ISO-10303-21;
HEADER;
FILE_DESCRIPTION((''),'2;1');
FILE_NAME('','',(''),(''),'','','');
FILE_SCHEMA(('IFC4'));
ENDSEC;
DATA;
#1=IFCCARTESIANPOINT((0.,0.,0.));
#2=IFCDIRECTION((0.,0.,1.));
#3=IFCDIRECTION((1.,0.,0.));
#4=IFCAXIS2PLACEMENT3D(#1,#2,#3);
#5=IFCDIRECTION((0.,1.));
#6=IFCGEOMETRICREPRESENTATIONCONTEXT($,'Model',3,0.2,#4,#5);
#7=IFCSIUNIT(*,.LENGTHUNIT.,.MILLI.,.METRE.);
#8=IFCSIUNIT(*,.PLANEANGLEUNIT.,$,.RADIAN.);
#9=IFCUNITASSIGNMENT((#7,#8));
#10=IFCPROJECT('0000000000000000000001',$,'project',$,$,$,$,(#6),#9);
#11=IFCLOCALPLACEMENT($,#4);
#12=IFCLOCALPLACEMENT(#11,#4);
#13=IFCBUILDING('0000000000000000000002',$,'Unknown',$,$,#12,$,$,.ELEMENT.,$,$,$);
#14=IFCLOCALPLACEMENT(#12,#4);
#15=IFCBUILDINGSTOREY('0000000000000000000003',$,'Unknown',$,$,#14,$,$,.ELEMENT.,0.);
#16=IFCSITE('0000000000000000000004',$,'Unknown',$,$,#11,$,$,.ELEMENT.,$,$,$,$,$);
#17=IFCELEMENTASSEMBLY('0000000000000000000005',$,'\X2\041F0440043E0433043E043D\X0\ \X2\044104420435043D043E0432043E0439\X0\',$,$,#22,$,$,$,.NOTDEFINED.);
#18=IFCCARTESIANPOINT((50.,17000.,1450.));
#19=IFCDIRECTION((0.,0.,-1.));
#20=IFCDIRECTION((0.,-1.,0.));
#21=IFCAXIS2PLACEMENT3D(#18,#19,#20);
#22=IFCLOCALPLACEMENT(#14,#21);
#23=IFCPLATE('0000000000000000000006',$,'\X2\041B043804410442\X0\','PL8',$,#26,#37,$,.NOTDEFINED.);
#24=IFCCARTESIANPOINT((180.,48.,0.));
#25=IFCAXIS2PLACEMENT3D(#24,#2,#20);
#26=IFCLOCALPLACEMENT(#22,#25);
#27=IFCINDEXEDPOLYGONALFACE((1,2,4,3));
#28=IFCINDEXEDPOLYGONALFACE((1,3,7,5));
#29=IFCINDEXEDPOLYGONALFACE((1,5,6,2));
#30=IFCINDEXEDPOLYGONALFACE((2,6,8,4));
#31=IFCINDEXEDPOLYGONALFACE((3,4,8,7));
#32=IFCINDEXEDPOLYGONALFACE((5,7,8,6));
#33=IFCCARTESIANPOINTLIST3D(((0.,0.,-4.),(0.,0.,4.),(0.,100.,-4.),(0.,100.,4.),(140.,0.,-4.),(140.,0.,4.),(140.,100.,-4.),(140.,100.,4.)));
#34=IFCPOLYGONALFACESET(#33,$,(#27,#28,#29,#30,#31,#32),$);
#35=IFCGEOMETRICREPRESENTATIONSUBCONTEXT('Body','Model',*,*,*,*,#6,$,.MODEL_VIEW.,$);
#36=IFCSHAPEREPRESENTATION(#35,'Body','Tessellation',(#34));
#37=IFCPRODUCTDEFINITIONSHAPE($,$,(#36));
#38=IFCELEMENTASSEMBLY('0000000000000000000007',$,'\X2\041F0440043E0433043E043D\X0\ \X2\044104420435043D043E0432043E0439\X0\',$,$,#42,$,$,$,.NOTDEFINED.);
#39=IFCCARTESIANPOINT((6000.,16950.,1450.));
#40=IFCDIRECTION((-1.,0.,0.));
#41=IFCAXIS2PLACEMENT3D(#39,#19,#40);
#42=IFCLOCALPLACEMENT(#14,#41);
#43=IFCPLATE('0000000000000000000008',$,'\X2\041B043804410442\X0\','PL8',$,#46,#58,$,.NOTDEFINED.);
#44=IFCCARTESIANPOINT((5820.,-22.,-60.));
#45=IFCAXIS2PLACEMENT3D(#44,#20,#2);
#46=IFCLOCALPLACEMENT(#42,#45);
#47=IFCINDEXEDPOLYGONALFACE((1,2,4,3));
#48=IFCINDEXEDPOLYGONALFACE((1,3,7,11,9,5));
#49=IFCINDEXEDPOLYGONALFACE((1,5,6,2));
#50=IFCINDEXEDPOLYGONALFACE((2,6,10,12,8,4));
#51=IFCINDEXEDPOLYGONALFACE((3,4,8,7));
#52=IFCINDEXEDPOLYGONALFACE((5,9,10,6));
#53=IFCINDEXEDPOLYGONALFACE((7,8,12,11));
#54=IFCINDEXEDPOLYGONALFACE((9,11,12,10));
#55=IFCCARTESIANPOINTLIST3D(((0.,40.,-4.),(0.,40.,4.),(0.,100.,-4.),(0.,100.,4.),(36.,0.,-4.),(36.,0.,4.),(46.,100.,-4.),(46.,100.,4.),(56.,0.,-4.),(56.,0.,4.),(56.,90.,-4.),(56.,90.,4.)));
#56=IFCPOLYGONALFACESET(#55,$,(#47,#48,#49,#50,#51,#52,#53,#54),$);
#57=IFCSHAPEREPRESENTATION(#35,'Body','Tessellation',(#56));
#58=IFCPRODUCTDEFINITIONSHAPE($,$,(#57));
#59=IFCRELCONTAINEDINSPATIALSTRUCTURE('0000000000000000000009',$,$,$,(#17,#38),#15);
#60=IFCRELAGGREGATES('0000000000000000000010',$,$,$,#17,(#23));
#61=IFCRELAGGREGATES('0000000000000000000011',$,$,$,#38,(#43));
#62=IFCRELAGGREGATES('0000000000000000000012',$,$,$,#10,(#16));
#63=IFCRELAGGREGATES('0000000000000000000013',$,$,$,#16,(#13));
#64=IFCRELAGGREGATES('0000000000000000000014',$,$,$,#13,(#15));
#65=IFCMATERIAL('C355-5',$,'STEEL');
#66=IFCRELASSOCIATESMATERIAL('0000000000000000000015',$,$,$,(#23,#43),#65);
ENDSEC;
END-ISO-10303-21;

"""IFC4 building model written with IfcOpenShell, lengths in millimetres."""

from ifc_helpers import new_model, si_unit, direction, frame, origin_with_axes, place, context, subcontext, project, spatial, line, indexed_curve, outline, extrude, material, element, aggregate, save


model = new_model("IFC4")

# Units and contexts
model_context = context("Model", 3, precision=0.2, world=origin_with_axes(), true_north=direction((0.0, 1.0)))
body_context = subcontext(model_context, "Body", "Model", "MODEL_VIEW")
ifc_project = project(units=[si_unit("LENGTHUNIT", "METRE", prefix="MILLI"), si_unit("PLANEANGLEUNIT", "RADIAN")], contexts=[model_context])

# Site, building, storey
site_placement = place(None, origin_with_axes())
site = spatial("IfcSite", under=ifc_project, at=site_placement, Name="Unknown", CompositionType="ELEMENT")
building_placement = place(site_placement, origin_with_axes())
building = spatial("IfcBuilding", under=site, at=building_placement, Name="Unknown", CompositionType="ELEMENT")
storey_placement = place(building_placement, origin_with_axes())
storey = spatial("IfcBuildingStorey", under=building, at=storey_placement, Name="Unknown", CompositionType="ELEMENT", Elevation=0.0)

# Element assemblies, plates
ifc_material_1 = material(Name="C355-5", Category="STEEL")
assembly_1_placement = place(storey_placement, frame((50.0, 17000.0, 1450.0), z_axis=(0.0, 0.0, -1.0), x_axis=(0.0, -1.0, 0.0)))
assembly_1 = element("IfcElementAssembly", 1, at=assembly_1_placement, inside=storey, Name="Прогон стеновой", PredefinedType="NOTDEFINED")
plate_1_placement = place(assembly_1_placement, frame((180.0, 48.0, 0.0), z_axis=(0.0, 0.0, 1.0), x_axis=(0.0, -1.0, 0.0)))
plate_1 = element("IfcPlate", 2, at=plate_1_placement, material=ifc_material_1, Name="Лист", Description="PL8", PredefinedType="NOTDEFINED", context=body_context, shape_type="SolidModel", body=[
    extrude(outline(indexed_curve([(0.0, 0.0), (140.0, 0.0), (140.0, 100.0), (0.0, 100.0)], segments=[line(1, 2, 3, 4, 1)])), frame((0.0, 0.0, 4.0), z_axis=(0.0, 0.0, 1.0), x_axis=(1.0, 0.0, 0.0)), (0.0, 0.0, -1.0), 8.0),
])
aggregate(assembly_1, [plate_1])
assembly_2_placement = place(storey_placement, frame((6000.0, 16950.0, 1450.0), z_axis=(0.0, 0.0, -1.0), x_axis=(-1.0, 0.0, 0.0)))
assembly_2 = element("IfcElementAssembly", 3, at=assembly_2_placement, inside=storey, Name="Прогон стеновой", PredefinedType="NOTDEFINED")
plate_2_placement = place(assembly_2_placement, frame((5820.0, -22.0, -60.0), z_axis=(0.0, -1.0, 0.0), x_axis=(0.0, 0.0, 1.0)))
plate_2 = element("IfcPlate", 4, at=plate_2_placement, material=ifc_material_1, Name="Лист", Description="PL8", PredefinedType="NOTDEFINED", context=body_context, shape_type="SolidModel", body=[
    extrude(outline(indexed_curve([(0.0, 40.0), (36.0, 0.0), (56.0, 0.0), (56.0, 90.0), (46.0, 100.0), (0.0, 100.0)], segments=[line(1, 2, 3, 4, 5, 6, 1)])), frame((0.0, 0.0, 4.0), z_axis=(0.0, 0.0, 1.0), x_axis=(1.0, 0.0, 0.0)), (0.0, 0.0, -1.0), 8.0),
])
aggregate(assembly_2, [plate_2])

save(model, "model.ifc")
